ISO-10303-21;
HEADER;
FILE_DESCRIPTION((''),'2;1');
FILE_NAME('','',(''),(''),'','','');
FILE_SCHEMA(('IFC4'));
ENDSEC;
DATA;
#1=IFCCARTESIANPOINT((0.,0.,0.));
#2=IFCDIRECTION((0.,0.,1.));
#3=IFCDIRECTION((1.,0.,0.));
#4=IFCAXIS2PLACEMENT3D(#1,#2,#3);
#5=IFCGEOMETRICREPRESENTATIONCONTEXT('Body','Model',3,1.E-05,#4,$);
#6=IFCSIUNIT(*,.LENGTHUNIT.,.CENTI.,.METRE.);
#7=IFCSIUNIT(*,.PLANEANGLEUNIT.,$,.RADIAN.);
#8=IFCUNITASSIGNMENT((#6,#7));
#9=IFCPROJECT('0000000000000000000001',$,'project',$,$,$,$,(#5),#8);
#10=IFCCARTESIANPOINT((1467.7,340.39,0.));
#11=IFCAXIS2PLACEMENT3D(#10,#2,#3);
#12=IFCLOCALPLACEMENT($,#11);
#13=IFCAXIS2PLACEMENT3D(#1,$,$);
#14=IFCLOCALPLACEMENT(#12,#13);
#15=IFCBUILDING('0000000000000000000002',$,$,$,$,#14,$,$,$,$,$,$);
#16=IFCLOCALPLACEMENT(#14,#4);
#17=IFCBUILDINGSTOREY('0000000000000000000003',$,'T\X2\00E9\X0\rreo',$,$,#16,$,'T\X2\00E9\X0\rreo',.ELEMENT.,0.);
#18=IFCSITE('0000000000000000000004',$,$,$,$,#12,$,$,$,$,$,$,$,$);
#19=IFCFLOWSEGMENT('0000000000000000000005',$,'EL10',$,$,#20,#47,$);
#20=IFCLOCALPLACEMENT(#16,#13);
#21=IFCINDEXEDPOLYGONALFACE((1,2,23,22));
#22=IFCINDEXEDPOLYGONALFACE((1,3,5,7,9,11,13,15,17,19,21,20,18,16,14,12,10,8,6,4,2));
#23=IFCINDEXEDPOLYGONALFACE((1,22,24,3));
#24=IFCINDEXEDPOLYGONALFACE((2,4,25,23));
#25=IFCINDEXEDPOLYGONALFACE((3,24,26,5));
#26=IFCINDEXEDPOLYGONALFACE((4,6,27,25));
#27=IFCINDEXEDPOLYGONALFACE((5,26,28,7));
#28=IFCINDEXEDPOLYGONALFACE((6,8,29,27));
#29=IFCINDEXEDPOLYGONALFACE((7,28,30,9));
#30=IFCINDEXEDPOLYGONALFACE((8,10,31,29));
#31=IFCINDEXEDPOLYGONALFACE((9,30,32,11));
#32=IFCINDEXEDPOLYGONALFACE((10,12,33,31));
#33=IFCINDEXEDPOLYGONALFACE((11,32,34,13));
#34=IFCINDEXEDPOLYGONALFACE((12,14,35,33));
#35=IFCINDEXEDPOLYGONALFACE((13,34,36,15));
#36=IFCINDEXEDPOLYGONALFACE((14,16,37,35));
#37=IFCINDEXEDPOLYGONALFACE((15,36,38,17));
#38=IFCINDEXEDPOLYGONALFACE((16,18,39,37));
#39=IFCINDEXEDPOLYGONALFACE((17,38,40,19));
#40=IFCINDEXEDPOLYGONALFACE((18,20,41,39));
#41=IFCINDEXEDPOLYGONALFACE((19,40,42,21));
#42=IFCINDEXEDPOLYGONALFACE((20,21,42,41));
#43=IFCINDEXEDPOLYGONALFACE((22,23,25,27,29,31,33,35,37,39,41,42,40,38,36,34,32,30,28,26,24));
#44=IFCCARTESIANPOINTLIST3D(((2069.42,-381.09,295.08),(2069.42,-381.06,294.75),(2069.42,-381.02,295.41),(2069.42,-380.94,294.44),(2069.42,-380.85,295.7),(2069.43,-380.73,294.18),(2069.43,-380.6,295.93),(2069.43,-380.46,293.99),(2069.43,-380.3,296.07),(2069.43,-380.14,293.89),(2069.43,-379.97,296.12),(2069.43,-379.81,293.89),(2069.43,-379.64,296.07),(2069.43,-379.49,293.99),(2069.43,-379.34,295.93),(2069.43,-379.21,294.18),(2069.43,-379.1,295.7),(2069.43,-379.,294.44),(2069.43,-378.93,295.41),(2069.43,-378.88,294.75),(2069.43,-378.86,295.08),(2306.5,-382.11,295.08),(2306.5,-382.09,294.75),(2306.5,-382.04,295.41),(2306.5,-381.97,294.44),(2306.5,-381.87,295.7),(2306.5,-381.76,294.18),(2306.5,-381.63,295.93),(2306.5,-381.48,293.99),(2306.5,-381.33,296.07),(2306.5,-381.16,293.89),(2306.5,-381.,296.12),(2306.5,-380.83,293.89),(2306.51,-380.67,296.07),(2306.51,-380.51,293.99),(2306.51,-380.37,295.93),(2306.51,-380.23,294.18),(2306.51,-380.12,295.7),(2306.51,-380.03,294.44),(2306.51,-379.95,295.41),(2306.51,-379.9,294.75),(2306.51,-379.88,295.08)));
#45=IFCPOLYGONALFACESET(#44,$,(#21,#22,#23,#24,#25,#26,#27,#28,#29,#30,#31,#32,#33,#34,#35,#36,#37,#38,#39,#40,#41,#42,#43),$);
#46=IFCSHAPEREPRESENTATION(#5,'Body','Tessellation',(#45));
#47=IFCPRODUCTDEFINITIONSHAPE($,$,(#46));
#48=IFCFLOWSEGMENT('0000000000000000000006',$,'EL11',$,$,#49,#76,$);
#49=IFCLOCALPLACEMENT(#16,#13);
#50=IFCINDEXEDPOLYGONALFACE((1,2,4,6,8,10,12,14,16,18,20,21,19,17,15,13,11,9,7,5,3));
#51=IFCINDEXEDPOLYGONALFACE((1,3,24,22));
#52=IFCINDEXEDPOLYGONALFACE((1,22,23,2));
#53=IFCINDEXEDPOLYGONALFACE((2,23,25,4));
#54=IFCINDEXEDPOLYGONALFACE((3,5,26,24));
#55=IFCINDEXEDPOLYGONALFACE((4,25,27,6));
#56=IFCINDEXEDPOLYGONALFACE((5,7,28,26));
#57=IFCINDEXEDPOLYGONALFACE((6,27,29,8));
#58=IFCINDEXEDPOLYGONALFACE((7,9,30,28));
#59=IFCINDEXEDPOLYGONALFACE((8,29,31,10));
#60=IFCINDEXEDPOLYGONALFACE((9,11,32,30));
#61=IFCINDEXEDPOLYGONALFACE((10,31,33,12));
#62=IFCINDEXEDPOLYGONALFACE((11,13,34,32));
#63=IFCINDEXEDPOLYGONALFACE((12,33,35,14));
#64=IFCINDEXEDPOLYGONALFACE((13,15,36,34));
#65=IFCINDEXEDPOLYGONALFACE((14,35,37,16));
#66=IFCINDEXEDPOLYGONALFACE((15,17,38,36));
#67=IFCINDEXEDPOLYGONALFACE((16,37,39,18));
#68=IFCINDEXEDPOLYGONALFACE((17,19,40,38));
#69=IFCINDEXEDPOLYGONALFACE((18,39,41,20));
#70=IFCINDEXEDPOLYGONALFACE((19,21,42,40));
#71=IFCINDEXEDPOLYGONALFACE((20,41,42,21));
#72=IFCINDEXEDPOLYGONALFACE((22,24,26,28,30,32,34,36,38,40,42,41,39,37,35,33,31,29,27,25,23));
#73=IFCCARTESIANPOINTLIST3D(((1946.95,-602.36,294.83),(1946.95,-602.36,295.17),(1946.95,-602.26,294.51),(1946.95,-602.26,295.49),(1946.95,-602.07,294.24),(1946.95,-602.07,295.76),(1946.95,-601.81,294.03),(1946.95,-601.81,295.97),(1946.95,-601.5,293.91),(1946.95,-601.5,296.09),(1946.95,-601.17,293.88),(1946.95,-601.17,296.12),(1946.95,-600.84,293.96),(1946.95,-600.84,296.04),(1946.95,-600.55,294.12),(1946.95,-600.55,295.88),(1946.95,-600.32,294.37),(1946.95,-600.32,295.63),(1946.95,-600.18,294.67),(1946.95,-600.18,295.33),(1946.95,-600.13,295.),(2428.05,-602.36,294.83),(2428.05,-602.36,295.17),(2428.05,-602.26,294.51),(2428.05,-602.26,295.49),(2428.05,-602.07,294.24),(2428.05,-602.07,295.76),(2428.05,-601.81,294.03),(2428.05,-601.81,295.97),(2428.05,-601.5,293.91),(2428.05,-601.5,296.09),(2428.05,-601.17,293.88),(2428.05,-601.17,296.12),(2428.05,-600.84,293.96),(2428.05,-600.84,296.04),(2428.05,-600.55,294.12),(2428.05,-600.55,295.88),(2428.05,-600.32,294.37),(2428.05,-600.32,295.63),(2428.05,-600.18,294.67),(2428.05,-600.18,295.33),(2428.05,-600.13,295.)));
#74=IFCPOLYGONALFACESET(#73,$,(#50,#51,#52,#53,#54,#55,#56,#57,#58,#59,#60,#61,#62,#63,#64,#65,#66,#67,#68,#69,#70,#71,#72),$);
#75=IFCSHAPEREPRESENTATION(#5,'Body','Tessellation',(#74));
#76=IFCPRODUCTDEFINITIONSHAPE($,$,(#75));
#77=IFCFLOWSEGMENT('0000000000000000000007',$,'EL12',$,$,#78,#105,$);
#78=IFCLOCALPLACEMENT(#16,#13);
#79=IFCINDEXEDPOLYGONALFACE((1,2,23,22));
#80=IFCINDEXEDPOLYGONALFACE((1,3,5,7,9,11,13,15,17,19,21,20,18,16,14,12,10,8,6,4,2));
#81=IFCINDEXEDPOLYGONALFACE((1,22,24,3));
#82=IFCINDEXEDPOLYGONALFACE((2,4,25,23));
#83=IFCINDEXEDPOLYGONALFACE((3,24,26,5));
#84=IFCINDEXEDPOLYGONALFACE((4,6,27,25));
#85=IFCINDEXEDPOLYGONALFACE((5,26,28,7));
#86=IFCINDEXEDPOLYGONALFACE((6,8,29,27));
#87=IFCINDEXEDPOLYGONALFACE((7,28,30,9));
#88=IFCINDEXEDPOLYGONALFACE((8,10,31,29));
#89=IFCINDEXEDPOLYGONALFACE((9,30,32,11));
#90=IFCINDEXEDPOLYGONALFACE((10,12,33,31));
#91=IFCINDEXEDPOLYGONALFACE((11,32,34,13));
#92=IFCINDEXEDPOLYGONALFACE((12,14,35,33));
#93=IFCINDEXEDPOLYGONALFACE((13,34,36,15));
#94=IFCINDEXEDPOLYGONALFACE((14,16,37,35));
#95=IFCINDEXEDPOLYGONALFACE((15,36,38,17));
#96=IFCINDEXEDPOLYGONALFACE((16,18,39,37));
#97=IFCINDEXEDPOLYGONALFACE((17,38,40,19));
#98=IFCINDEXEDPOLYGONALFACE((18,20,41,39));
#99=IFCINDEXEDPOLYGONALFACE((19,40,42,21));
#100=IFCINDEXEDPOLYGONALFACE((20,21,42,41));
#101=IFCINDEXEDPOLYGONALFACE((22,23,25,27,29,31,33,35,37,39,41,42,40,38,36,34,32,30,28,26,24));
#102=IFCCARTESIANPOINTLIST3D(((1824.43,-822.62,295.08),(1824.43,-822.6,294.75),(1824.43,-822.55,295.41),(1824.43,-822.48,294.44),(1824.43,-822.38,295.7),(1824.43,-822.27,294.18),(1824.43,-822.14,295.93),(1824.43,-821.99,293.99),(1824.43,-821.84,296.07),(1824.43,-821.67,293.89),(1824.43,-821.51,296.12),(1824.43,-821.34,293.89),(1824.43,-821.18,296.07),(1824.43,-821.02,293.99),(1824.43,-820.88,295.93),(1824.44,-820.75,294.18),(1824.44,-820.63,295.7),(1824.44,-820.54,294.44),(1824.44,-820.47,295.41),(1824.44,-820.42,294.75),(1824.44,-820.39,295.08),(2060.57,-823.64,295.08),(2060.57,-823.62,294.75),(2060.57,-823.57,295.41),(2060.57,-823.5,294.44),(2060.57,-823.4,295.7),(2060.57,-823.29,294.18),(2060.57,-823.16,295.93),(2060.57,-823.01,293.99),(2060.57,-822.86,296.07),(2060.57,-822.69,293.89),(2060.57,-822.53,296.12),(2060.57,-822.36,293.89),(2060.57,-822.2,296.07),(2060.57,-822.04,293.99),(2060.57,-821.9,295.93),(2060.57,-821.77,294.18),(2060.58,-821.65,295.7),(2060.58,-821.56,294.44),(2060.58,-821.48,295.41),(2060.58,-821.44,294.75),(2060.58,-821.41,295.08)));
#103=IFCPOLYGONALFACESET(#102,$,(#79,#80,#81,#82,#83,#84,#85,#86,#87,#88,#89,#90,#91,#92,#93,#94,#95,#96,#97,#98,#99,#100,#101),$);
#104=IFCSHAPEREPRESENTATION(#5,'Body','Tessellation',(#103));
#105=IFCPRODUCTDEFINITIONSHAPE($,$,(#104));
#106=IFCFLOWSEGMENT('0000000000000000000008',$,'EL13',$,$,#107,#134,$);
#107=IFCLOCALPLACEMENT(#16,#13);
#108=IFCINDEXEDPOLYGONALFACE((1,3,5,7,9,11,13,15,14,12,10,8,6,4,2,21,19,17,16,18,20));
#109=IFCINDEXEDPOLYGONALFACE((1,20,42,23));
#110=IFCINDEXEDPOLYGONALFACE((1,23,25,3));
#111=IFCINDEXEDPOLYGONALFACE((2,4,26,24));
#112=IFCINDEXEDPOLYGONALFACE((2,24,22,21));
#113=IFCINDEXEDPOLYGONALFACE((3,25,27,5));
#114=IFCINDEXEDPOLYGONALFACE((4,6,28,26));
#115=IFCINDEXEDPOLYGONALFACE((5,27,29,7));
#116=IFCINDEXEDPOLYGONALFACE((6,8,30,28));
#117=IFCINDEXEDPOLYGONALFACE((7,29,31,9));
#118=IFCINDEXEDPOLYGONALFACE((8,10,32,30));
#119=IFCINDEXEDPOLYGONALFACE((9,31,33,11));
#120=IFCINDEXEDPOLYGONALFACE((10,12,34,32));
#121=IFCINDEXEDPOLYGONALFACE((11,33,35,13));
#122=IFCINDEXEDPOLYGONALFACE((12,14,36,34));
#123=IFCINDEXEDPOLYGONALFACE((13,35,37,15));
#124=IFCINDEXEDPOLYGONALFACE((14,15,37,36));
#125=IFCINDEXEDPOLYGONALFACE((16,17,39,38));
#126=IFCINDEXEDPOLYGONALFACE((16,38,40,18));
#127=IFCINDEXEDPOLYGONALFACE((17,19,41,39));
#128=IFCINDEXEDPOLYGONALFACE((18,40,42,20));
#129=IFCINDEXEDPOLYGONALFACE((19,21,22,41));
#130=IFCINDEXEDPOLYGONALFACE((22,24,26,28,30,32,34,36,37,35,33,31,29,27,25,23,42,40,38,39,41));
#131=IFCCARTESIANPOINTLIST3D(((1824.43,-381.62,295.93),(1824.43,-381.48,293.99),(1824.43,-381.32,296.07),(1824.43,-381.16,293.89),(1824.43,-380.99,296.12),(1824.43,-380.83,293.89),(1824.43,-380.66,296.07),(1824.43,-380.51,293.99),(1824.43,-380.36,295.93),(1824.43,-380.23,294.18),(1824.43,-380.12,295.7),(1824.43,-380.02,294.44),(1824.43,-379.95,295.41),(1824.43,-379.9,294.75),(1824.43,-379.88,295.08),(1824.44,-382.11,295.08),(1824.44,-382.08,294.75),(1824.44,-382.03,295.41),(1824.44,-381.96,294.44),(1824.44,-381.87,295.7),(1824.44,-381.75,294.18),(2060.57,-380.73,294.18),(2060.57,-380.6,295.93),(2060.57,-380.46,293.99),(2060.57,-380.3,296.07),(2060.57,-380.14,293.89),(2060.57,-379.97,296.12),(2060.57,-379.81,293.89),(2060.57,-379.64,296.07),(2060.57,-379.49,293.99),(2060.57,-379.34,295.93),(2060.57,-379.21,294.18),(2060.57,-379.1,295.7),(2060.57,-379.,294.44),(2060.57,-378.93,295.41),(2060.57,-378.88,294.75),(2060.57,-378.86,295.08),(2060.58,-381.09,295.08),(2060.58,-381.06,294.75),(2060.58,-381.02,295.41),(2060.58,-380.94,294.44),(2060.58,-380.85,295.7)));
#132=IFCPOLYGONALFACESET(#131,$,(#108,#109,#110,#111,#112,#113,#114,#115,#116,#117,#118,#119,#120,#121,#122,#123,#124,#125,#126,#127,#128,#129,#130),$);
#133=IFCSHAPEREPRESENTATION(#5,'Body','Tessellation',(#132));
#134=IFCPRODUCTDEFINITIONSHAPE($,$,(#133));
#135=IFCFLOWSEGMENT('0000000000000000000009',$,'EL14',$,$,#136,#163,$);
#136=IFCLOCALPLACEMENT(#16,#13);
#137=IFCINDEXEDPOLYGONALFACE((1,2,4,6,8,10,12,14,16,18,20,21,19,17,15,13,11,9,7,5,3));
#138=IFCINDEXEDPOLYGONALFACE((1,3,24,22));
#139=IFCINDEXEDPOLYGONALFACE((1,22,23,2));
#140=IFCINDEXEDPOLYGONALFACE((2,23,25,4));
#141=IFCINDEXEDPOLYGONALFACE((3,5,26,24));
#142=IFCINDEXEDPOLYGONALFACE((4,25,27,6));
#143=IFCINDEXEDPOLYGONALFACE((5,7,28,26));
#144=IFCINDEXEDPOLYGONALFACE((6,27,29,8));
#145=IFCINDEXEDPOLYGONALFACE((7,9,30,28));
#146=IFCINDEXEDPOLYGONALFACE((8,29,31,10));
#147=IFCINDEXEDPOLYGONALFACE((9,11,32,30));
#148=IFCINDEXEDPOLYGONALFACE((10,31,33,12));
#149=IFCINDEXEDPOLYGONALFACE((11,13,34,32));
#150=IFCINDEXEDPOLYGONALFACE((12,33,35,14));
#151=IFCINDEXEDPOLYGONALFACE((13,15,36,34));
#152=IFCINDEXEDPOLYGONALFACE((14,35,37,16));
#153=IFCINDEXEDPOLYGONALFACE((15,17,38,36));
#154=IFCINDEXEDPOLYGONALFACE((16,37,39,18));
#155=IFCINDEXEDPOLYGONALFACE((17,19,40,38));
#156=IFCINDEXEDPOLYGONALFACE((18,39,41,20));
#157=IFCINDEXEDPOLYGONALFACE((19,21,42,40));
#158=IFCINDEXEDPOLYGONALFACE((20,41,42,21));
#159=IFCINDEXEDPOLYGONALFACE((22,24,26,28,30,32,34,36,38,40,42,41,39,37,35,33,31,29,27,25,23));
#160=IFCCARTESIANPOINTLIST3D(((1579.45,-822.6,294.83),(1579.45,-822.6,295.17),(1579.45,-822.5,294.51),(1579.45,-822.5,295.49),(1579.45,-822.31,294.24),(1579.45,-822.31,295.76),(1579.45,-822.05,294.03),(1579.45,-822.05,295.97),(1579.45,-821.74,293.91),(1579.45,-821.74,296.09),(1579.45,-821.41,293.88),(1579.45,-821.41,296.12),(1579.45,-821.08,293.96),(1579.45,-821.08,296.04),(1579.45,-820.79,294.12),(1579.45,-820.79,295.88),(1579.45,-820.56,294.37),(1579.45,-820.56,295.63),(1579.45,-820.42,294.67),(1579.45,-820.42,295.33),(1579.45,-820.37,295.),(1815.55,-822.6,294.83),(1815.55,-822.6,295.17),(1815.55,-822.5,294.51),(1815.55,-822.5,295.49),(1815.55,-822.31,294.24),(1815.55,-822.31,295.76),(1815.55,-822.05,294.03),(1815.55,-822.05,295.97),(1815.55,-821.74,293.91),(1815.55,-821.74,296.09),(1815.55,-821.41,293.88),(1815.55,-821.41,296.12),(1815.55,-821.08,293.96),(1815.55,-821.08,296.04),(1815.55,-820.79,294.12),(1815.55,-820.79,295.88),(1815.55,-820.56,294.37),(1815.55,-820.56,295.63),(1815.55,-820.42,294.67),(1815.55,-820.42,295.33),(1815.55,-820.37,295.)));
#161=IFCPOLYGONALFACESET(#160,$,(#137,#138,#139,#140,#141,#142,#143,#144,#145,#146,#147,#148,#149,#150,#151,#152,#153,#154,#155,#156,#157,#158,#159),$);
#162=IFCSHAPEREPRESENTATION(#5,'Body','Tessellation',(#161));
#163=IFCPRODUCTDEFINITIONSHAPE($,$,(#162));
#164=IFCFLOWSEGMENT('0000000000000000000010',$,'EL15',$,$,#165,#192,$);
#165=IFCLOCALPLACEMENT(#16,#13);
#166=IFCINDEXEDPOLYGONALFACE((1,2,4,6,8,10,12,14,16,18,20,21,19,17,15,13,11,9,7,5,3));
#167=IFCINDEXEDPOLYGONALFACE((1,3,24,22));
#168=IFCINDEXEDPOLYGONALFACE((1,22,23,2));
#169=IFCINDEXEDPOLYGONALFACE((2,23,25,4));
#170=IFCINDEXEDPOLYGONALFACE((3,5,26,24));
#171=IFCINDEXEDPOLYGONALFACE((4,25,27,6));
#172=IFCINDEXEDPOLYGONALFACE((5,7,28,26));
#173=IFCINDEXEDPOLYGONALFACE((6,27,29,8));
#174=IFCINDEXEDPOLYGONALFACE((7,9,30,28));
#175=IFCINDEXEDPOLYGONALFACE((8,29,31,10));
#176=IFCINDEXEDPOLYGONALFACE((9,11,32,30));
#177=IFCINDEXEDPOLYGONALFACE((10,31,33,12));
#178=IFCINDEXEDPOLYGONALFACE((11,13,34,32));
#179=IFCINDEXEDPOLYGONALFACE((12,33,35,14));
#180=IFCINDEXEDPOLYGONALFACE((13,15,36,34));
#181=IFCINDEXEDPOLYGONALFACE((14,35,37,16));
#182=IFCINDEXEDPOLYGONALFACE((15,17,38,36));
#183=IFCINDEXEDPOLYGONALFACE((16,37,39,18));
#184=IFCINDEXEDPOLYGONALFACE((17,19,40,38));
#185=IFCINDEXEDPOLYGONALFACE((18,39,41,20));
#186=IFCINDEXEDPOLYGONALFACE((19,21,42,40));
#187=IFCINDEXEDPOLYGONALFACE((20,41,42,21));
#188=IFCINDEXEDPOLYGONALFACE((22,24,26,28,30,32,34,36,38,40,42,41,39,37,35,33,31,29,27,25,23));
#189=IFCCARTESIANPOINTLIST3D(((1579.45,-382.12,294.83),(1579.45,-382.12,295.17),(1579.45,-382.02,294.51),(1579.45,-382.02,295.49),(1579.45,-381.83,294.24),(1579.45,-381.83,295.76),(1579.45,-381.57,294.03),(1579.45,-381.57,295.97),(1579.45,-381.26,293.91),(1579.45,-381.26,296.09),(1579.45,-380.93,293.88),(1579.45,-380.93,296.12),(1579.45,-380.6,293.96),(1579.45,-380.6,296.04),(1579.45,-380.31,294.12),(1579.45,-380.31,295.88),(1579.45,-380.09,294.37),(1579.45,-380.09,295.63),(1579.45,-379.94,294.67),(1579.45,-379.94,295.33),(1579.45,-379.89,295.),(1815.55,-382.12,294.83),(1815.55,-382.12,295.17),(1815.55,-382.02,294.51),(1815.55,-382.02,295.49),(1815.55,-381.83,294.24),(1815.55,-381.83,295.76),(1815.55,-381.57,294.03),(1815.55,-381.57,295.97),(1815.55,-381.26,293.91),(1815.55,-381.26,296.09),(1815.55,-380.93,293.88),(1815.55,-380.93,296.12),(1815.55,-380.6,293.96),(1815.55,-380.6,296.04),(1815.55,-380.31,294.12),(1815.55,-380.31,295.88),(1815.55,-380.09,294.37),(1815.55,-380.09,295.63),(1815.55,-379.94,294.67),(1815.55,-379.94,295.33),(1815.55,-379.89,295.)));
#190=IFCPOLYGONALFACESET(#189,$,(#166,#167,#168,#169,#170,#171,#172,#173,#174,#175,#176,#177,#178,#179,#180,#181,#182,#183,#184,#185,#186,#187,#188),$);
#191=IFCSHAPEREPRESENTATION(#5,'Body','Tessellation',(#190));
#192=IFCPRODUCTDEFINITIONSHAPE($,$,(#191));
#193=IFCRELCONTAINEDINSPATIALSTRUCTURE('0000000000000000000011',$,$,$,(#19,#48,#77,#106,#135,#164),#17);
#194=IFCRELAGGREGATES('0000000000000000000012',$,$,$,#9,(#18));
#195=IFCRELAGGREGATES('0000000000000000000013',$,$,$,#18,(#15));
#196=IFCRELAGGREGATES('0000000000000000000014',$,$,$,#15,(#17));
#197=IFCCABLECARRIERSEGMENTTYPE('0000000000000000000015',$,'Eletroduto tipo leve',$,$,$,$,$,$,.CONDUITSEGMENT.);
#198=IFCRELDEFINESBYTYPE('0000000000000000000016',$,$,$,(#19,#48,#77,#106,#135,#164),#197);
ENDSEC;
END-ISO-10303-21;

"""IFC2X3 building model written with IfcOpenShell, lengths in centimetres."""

from ifc_helpers import new_model, si_unit, frame, origin, origin_with_axes, origin_2d_with_axis, place, context, project, spatial, circle, extrude, type_object, element, save


model = new_model("IFC2X3")

# Units and contexts
model_context = context("Model", 3, precision=1e-05, world=origin_with_axes(), identifier="Body")
ifc_project = project(units=[si_unit("LENGTHUNIT", "METRE", prefix="CENTI"), si_unit("PLANEANGLEUNIT", "RADIAN")], contexts=[model_context])

# Site, building, storey
site_placement = place(None, frame((1467.7, 340.39, 0.0), z_axis=(0.0, 0.0, 1.0), x_axis=(1.0, 0.0, 0.0)))
site = spatial("IfcSite", under=ifc_project, at=site_placement)
building_placement = place(site_placement, origin())
building = spatial("IfcBuilding", under=site, at=building_placement)
storey_placement = place(building_placement, origin_with_axes())
storey = spatial("IfcBuildingStorey", under=building, at=storey_placement, Name="Térreo", LongName="Térreo", CompositionType="ELEMENT", Elevation=0.0)

# Flow segments
cable_carrier_segment_type = type_object("IfcCableCarrierSegmentType", Name="Eletroduto tipo leve", PredefinedType="CONDUITSEGMENT")
flow_segment_1_placement = place(storey_placement, frame((2187.97, -380.48, 296.12), z_axis=(0.0, 0.0, 1.0), x_axis=(1.0, 0.0, 0.0)))
element("IfcFlowSegment", 1, at=flow_segment_1_placement, inside=storey, type_object=cable_carrier_segment_type, Name="EL10", context=model_context, shape_type="SolidModel", body=[
    extrude(circle(Radius=1.12, at=origin_2d_with_axis()), frame((118.54, -0.51, -1.12), z_axis=(-1.0, 0.004317, 0.0), x_axis=(0.0, 0.0, 1.0)), (0.0, 0.0, 1.0), 237.08),
])
flow_segment_2_placement = place(storey_placement, frame((2187.5, -601.25, 296.12), z_axis=(0.0, 0.0, 1.0), x_axis=(1.0, 0.0, 0.0)))
element("IfcFlowSegment", 2, at=flow_segment_2_placement, inside=storey, type_object=cable_carrier_segment_type, Name="EL11", context=model_context, shape_type="SolidModel", body=[
    extrude(circle(Radius=1.12, at=origin_2d_with_axis()), frame((240.55, 0.0, -1.12), z_axis=(-1.0, 0.0, 0.0), x_axis=(0.0, 1.0, 0.0)), (0.0, 0.0, 1.0), 481.1),
])
flow_segment_3_placement = place(storey_placement, frame((1942.5, -822.02, 296.12), z_axis=(0.0, 0.0, 1.0), x_axis=(1.0, 0.0, 0.0)))
element("IfcFlowSegment", 3, at=flow_segment_3_placement, inside=storey, type_object=cable_carrier_segment_type, Name="EL12", context=model_context, shape_type="SolidModel", body=[
    extrude(circle(Radius=1.12, at=origin_2d_with_axis()), frame((118.07, -0.51, -1.12), z_axis=(-1.0, 0.004317, 0.0), x_axis=(0.0, 0.0, 1.0)), (0.0, 0.0, 1.0), 236.14),
])
flow_segment_4_placement = place(storey_placement, frame((1942.5, -380.48, 296.12), z_axis=(0.0, 0.0, 1.0), x_axis=(1.0, 0.0, 0.0)))
element("IfcFlowSegment", 4, at=flow_segment_4_placement, inside=storey, type_object=cable_carrier_segment_type, Name="EL13", context=model_context, shape_type="SolidModel", body=[
    extrude(circle(Radius=1.12, at=origin_2d_with_axis()), frame((118.07, 0.51, -1.12), z_axis=(-1.0, -0.004317, 0.0), x_axis=(0.0, 0.0, 1.0)), (0.0, 0.0, 1.0), 236.14),
])
flow_segment_5_placement = place(storey_placement, frame((1697.5, -821.49, 296.12), z_axis=(0.0, 0.0, 1.0), x_axis=(1.0, 0.0, 0.0)))
element("IfcFlowSegment", 5, at=flow_segment_5_placement, inside=storey, type_object=cable_carrier_segment_type, Name="EL14", context=model_context, shape_type="SolidModel", body=[
    extrude(circle(Radius=1.12, at=origin_2d_with_axis()), frame((118.05, 0.0, -1.12), z_axis=(-1.0, 0.0, 0.0), x_axis=(0.0, 1.0, 0.0)), (0.0, 0.0, 1.0), 236.1),
])
flow_segment_6_placement = place(storey_placement, frame((1697.5, -381.01, 296.12), z_axis=(0.0, 0.0, 1.0), x_axis=(1.0, 0.0, 0.0)))
element("IfcFlowSegment", 6, at=flow_segment_6_placement, inside=storey, type_object=cable_carrier_segment_type, Name="EL15", context=model_context, shape_type="SolidModel", body=[
    extrude(circle(Radius=1.12, at=origin_2d_with_axis()), frame((118.05, 0.0, -1.12), z_axis=(-1.0, 0.0, 0.0), x_axis=(0.0, 1.0, 0.0)), (0.0, 0.0, 1.0), 236.1),
])

save(model, "model.ifc")
